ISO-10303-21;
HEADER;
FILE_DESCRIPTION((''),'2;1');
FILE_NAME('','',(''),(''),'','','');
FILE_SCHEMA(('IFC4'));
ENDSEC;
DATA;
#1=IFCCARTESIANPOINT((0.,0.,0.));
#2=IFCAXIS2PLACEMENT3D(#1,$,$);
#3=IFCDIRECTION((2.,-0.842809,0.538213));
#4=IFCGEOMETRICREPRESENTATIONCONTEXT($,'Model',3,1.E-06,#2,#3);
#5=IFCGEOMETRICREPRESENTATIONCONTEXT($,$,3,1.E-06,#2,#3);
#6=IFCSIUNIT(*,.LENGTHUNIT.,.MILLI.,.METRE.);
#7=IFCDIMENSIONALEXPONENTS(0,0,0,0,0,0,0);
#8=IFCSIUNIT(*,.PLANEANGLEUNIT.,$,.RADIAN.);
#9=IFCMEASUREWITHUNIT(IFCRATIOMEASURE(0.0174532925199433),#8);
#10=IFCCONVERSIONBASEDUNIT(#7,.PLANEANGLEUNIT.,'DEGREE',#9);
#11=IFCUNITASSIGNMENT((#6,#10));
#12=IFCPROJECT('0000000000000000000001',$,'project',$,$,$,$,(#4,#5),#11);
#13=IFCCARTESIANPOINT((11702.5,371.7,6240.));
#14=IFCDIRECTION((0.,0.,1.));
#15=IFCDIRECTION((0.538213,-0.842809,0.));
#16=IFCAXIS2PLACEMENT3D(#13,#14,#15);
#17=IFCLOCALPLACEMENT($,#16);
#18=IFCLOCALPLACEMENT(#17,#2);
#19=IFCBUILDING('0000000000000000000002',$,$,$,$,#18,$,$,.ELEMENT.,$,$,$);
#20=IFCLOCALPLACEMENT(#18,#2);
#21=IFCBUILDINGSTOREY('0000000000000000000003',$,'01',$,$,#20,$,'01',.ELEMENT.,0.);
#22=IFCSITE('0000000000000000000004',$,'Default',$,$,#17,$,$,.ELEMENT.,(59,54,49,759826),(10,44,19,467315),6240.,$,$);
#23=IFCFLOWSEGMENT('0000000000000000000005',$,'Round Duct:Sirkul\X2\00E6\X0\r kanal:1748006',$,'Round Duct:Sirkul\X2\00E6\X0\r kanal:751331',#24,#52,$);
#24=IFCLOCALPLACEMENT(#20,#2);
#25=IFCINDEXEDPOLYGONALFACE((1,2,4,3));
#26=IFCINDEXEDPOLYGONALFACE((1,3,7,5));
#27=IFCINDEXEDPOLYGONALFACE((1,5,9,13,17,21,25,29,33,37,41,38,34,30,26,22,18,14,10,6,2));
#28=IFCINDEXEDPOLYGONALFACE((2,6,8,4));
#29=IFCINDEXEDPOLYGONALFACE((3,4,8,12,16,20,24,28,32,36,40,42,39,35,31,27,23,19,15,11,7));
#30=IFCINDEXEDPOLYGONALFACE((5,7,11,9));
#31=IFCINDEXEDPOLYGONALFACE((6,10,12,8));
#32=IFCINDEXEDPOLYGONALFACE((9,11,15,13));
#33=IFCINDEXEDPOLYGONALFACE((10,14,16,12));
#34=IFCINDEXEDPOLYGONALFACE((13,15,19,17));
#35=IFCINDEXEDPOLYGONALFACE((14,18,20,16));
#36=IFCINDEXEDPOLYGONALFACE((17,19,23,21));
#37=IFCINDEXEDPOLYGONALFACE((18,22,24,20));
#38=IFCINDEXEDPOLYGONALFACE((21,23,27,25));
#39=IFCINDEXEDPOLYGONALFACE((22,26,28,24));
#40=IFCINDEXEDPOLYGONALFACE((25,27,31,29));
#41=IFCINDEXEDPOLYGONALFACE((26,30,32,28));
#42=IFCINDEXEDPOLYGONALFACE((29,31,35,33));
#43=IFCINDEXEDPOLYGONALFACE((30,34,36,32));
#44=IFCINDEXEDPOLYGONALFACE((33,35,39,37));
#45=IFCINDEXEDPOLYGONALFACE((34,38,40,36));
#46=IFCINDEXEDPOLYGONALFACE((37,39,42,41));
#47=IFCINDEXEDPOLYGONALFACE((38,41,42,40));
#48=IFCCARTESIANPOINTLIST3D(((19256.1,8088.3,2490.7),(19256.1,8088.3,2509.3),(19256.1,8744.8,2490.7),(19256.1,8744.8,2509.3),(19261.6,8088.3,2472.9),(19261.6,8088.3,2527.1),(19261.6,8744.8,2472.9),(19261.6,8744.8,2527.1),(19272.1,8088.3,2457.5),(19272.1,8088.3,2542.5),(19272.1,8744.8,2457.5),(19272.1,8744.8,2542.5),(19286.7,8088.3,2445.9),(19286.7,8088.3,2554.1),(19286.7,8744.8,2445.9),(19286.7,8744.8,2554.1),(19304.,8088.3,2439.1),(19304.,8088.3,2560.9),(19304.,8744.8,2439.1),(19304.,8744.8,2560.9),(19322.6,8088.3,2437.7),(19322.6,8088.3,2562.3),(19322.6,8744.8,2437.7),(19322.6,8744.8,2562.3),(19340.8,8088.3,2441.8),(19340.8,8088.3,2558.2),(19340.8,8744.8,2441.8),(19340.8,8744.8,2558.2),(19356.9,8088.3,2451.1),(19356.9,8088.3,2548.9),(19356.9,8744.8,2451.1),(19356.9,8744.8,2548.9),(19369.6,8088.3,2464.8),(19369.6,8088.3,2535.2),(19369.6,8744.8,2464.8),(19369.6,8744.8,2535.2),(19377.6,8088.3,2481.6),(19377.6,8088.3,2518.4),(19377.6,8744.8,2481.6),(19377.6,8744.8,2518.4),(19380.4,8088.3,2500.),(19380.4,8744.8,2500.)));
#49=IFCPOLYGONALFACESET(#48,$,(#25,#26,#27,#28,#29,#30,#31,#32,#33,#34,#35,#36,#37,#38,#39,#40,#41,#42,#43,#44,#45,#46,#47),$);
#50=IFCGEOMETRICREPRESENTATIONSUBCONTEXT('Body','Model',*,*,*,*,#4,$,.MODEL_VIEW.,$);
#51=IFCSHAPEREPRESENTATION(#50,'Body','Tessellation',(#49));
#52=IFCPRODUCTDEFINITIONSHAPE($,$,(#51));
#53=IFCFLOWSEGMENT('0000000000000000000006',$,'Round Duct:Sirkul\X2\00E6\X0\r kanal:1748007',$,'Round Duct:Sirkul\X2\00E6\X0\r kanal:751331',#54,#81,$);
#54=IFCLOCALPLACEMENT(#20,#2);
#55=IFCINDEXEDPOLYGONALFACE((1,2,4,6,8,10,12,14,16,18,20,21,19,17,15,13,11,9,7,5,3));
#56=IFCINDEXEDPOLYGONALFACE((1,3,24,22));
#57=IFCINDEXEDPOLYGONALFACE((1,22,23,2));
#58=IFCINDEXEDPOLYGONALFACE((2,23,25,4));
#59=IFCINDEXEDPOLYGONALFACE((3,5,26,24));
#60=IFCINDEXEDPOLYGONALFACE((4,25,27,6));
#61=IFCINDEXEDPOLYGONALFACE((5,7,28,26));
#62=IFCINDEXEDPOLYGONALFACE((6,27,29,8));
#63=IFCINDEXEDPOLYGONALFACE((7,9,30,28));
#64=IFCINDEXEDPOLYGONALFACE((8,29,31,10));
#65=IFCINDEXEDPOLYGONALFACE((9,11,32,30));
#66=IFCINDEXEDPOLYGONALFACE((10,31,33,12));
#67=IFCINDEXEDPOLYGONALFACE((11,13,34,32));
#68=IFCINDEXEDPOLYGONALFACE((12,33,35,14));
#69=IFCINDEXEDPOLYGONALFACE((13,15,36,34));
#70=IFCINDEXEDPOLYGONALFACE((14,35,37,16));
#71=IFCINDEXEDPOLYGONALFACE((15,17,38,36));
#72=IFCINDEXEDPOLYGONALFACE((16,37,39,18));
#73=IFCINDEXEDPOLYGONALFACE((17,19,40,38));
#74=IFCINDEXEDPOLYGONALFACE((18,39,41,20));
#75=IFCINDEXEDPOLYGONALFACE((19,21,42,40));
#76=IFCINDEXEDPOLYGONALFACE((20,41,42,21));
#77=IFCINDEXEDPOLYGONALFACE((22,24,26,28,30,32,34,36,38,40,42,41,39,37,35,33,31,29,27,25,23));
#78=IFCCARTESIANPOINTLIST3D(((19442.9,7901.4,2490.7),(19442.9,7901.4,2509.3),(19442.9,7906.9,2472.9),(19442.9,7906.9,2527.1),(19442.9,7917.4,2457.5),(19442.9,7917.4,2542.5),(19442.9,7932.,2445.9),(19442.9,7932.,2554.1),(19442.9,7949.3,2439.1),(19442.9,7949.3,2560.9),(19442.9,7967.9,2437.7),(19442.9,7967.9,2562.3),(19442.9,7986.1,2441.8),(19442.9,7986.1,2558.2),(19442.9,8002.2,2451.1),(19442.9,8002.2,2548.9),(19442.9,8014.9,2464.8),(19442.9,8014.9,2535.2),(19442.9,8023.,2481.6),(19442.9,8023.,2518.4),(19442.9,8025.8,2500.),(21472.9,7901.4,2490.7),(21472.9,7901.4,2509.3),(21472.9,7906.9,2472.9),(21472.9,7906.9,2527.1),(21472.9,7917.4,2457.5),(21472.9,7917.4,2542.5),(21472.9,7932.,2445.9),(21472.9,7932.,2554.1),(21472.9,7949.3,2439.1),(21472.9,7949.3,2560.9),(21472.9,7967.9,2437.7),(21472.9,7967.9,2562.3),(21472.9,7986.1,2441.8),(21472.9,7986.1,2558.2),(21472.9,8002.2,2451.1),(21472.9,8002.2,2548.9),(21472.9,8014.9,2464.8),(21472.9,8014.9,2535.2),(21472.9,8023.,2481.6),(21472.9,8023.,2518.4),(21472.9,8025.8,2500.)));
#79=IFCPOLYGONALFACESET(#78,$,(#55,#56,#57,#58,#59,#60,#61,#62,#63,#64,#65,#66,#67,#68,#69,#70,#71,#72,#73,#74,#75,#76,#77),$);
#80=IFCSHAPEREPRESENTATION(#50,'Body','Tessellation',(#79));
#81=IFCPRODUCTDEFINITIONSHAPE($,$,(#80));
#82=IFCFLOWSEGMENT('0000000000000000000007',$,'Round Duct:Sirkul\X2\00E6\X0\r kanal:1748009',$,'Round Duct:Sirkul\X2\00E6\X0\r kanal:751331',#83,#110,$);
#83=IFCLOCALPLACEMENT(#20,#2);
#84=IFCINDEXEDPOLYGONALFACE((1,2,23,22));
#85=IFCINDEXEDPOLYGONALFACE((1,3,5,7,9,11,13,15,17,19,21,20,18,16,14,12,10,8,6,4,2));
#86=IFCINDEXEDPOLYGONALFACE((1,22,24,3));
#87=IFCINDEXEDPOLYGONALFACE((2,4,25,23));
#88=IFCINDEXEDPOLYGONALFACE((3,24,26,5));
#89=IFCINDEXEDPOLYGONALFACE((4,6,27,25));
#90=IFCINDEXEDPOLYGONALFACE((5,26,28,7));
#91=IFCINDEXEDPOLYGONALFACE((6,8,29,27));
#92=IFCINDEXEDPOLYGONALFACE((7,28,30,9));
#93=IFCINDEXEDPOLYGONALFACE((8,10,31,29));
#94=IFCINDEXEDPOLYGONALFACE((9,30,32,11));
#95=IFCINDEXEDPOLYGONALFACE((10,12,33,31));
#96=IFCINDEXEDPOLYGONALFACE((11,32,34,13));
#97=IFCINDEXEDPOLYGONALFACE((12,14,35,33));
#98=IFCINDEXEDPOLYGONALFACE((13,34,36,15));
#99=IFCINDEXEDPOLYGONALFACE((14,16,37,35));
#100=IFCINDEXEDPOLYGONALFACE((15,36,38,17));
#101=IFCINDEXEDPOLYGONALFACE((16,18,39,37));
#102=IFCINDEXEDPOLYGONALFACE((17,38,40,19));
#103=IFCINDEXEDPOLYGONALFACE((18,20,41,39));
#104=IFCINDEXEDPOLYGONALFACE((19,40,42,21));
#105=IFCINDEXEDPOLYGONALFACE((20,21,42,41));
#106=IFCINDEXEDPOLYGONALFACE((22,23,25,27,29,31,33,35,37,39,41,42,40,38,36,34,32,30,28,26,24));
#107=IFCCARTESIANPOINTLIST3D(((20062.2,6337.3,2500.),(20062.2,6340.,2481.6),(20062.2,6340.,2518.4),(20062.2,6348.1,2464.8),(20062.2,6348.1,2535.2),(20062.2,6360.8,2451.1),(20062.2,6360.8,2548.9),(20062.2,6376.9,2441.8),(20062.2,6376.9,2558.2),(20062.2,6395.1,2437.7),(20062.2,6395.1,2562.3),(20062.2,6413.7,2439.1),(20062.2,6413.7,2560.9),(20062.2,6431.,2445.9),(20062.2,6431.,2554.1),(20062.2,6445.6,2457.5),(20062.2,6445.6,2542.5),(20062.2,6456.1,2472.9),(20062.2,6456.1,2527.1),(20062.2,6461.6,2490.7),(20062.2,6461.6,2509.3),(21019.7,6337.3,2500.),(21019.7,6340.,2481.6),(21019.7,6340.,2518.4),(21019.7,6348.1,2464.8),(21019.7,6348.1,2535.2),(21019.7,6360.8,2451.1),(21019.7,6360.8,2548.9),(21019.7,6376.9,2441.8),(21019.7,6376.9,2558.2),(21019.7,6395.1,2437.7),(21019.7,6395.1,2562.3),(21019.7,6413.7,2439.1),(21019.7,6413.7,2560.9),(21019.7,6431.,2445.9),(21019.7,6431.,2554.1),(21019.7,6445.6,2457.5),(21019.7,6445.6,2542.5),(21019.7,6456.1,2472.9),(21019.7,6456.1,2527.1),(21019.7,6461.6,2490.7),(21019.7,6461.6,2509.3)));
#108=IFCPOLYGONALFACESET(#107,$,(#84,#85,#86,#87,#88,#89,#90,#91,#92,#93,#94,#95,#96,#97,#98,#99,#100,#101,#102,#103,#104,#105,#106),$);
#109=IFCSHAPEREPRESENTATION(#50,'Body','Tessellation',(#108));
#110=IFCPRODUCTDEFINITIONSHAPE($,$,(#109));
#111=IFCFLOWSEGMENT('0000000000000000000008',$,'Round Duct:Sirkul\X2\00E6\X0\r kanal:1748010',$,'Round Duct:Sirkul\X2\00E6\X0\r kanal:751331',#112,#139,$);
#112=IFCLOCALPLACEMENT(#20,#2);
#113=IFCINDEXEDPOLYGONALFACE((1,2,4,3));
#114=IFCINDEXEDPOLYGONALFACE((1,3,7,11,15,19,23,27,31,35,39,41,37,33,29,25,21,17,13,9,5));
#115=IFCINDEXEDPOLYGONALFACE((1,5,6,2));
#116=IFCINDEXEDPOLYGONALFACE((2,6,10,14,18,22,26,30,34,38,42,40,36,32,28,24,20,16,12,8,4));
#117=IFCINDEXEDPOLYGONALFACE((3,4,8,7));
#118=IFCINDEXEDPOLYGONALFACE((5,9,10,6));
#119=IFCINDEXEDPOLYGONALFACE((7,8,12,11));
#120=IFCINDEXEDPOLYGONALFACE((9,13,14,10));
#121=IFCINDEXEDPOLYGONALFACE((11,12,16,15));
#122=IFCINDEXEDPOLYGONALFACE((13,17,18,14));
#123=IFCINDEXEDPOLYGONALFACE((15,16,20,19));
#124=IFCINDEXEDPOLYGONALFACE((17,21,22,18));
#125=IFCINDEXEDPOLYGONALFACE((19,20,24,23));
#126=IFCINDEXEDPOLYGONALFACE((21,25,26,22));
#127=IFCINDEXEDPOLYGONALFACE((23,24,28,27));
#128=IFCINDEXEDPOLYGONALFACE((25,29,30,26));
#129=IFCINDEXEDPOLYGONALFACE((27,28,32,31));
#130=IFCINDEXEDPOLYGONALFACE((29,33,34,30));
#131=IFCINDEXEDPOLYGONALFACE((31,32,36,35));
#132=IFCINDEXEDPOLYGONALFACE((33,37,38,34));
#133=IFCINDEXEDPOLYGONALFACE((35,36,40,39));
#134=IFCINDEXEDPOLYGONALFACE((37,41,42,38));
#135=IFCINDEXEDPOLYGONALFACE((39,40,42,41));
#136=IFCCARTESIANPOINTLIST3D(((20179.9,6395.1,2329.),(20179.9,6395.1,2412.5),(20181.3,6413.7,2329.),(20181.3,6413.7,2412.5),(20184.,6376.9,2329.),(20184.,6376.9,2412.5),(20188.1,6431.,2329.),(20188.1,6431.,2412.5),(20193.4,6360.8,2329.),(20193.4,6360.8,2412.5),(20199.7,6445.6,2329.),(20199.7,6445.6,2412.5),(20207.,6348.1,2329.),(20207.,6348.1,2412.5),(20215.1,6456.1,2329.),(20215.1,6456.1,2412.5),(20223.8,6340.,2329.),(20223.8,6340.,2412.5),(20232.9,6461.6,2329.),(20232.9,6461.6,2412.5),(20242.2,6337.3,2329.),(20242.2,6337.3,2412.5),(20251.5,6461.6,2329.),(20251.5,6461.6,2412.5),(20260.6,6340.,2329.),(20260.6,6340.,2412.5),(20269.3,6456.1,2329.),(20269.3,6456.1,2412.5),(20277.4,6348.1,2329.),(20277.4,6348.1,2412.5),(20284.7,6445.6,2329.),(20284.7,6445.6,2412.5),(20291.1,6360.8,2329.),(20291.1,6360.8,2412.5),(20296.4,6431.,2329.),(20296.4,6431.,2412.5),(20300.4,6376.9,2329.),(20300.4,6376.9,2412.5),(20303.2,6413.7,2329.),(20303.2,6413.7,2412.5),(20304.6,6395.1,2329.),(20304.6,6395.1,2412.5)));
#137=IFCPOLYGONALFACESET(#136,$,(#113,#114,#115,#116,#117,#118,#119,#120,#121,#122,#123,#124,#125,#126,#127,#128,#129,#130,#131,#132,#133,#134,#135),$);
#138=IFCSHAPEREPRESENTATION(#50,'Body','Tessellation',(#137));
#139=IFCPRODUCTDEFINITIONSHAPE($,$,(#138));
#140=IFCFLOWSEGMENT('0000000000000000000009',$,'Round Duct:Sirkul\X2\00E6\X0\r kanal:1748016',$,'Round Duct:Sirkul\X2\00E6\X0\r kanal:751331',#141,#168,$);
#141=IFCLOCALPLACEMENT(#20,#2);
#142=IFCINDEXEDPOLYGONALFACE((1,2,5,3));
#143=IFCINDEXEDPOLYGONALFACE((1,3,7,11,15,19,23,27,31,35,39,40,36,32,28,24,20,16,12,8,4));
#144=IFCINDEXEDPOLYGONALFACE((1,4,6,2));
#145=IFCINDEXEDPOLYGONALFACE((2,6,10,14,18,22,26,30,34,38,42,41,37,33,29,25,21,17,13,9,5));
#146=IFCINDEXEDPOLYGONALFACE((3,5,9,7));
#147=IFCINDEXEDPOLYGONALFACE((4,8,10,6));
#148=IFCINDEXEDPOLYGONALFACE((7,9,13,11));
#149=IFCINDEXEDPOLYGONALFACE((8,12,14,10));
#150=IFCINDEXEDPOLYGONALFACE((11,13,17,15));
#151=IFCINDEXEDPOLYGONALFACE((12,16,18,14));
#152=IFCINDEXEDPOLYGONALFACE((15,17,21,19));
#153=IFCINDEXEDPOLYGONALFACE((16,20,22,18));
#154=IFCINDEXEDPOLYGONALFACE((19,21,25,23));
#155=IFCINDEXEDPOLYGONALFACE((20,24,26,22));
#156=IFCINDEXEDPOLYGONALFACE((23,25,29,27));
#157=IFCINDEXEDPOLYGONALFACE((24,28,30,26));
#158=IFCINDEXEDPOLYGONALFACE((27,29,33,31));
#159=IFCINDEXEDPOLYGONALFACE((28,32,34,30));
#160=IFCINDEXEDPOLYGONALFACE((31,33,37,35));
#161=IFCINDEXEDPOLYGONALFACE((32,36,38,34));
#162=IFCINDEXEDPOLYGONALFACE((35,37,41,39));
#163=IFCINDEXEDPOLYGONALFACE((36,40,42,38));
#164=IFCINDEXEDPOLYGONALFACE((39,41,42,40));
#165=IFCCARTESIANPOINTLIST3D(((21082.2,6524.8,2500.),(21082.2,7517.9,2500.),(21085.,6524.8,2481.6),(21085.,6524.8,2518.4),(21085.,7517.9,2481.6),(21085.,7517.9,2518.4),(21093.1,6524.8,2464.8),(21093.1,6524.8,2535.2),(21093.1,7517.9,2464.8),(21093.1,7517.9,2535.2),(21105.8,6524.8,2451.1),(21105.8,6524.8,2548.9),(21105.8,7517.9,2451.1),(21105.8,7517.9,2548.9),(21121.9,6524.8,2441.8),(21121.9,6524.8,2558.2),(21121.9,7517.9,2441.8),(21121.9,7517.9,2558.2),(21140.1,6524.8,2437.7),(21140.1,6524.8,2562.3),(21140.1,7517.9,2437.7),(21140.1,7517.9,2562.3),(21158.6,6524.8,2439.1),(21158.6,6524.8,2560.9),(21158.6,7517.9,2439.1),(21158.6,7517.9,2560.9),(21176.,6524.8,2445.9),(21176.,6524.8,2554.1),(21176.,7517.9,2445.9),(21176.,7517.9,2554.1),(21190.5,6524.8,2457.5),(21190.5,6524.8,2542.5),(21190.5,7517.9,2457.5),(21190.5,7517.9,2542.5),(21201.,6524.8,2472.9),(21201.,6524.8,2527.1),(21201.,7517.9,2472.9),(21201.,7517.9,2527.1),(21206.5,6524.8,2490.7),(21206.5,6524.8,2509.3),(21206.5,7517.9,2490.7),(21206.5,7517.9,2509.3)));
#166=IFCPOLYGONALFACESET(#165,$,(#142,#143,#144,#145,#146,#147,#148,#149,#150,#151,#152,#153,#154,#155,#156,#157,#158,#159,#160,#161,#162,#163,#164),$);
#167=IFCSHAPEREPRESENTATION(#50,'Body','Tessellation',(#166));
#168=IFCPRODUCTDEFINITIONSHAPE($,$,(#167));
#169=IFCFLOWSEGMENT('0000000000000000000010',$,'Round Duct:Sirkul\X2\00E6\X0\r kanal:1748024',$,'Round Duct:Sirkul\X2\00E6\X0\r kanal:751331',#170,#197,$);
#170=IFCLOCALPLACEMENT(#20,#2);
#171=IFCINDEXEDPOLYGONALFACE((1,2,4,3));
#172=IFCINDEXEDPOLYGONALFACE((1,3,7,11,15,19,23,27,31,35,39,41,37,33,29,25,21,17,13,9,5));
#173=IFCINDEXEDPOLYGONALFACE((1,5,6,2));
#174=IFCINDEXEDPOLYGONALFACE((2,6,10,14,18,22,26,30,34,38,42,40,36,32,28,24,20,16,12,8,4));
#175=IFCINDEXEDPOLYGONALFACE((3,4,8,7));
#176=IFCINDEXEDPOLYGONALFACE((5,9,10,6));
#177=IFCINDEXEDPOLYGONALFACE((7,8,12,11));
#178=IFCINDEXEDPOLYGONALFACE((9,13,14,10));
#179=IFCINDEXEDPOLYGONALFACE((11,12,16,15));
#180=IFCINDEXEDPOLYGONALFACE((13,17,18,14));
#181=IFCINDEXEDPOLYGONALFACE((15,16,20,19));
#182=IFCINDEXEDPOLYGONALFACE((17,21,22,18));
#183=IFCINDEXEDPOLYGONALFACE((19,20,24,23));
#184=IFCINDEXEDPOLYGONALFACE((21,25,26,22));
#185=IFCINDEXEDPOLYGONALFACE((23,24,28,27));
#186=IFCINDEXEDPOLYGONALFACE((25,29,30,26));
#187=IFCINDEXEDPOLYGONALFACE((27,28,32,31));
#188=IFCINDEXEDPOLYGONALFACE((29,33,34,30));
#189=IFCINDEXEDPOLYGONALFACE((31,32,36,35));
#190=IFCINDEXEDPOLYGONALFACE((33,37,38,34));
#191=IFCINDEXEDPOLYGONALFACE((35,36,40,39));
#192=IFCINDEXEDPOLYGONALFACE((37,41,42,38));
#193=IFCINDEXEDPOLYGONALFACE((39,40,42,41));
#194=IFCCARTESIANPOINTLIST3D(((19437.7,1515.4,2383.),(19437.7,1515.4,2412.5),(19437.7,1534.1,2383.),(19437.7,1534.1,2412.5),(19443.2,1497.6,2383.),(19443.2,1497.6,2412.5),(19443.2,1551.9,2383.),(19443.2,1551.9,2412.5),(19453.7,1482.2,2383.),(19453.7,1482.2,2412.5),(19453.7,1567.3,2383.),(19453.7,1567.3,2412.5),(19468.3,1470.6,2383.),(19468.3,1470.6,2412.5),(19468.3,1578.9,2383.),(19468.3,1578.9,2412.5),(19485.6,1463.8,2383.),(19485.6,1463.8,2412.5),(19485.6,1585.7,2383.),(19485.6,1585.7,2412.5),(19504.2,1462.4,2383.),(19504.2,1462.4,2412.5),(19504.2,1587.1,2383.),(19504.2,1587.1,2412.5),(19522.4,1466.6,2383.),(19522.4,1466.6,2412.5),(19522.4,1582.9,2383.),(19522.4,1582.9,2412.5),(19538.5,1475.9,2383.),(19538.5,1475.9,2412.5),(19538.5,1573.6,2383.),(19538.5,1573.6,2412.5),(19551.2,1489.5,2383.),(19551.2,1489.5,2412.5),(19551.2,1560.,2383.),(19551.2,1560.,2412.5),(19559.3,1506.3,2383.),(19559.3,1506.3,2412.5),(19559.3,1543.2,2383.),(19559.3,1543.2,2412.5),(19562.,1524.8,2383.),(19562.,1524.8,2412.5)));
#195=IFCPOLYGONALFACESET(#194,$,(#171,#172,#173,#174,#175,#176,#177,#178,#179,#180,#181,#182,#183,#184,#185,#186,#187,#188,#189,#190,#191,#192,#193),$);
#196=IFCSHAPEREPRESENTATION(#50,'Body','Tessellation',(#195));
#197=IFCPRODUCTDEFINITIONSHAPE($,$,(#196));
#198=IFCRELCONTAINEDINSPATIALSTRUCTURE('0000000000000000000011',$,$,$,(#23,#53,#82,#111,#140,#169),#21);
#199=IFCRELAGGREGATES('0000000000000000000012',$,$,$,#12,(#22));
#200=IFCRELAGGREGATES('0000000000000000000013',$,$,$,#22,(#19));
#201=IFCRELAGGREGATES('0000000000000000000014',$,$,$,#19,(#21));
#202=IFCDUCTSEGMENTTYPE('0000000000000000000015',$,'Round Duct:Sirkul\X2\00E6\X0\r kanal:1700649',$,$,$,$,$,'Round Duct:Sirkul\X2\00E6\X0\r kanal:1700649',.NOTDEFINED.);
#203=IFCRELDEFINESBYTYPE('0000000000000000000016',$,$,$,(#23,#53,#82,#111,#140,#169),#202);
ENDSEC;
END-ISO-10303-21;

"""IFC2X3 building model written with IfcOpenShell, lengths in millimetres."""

from ifc_helpers import new_model, entity, si_unit, converted_unit, direction, frame, frame_2d, origin, origin_2d_with_axis, place, context, subcontext, project, spatial, circle, extrude, type_object, element, save


model = new_model("IFC2X3")

# Units and contexts
model_context = context("Model", 3, precision=1e-06, world=origin(), true_north=direction((2.0, -0.842809, 0.538213)))
context_of_model = context(None, 3, precision=1e-06, world=origin(), true_north=direction((2.0, -0.842809, 0.538213)))
body_context = subcontext(model_context, "Body", "Model", "MODEL_VIEW")
ifc_project = project(units=[si_unit("LENGTHUNIT", "METRE", prefix="MILLI"), converted_unit("PLANEANGLEUNIT", "DEGREE", entity("IfcRatioMeasure", 0.0174532925199433), si_unit("PLANEANGLEUNIT", "RADIAN"), dimensions=[0, 0, 0, 0, 0, 0, 0])], contexts=[model_context, context_of_model])

# Site, building, storey
site_placement = place(None, frame((11702.5, 371.7, 6240.0), z_axis=(0.0, 0.0, 1.0), x_axis=(0.538213, -0.842809, 0.0)))
site = spatial("IfcSite", under=ifc_project, at=site_placement, Name="Default", CompositionType="ELEMENT", RefLatitude=(59, 54, 49, 759826), RefLongitude=(10, 44, 19, 467315), RefElevation=6240.0)
building_placement = place(site_placement, origin())
building = spatial("IfcBuilding", under=site, at=building_placement, CompositionType="ELEMENT")
storey_placement = place(building_placement, origin())
storey = spatial("IfcBuildingStorey", under=building, at=storey_placement, Name="01", LongName="01", CompositionType="ELEMENT", Elevation=0.0)

# Flow segments
duct_segment_type_1 = type_object("IfcDuctSegmentType", Name="Round Duct:Sirkulær kanal:1700649", ElementType="Round Duct:Sirkulær kanal:1700649", PredefinedType="NOTDEFINED")
flow_segment_1_placement = place(storey_placement, origin())
element("IfcFlowSegment", 1, at=flow_segment_1_placement, inside=storey, type_object=duct_segment_type_1, Name="Round Duct:Sirkulær kanal:1748006", ObjectType="Round Duct:Sirkulær kanal:751331", context=body_context, shape_type="SweptSolid", body=[
    extrude(circle(Radius=62.5, at=origin_2d_with_axis()), frame((19317.9, 8088.3, 2500.0), z_axis=(0.0, 1.0, 0.0), x_axis=(1.0, 0.0, 0.0)), (0.0, 0.0, 1.0), 656.5),
])
flow_segment_2_placement = place(storey_placement, origin())
element("IfcFlowSegment", 2, at=flow_segment_2_placement, inside=storey, type_object=duct_segment_type_1, Name="Round Duct:Sirkulær kanal:1748007", ObjectType="Round Duct:Sirkulær kanal:751331", context=body_context, shape_type="SweptSolid", body=[
    extrude(circle(Radius=62.5, at=frame_2d((0.0, 0.0), x_axis=(1.0, 0.0))), frame((19442.9, 7963.3, 2500.0), z_axis=(1.0, 0.0, 0.0), x_axis=(0.0, 1.0, 0.0)), (0.0, 0.0, 1.0), 2030.0),
])
flow_segment_3_placement = place(storey_placement, origin())
element("IfcFlowSegment", 3, at=flow_segment_3_placement, inside=storey, type_object=duct_segment_type_1, Name="Round Duct:Sirkulær kanal:1748009", ObjectType="Round Duct:Sirkulær kanal:751331", context=body_context, shape_type="SweptSolid", body=[
    extrude(circle(Radius=62.5, at=origin_2d_with_axis()), frame((20062.2, 6399.8, 2500.0), z_axis=(1.0, 0.0, 0.0), x_axis=(0.0, -1.0, 0.0)), (0.0, 0.0, 1.0), 957.5),
])
flow_segment_4_placement = place(storey_placement, origin())
element("IfcFlowSegment", 4, at=flow_segment_4_placement, inside=storey, type_object=duct_segment_type_1, Name="Round Duct:Sirkulær kanal:1748010", ObjectType="Round Duct:Sirkulær kanal:751331", context=body_context, shape_type="SweptSolid", body=[
    extrude(circle(Radius=62.5, at=frame_2d((0.0, 0.0), x_axis=(1.0, 0.0))), frame((20242.2, 6399.8, 2329.0), z_axis=(0.0, 0.0, 1.0), x_axis=(0.0, -1.0, 0.0)), (0.0, 0.0, 1.0), 83.5),
])
flow_segment_5_placement = place(storey_placement, origin())
element("IfcFlowSegment", 5, at=flow_segment_5_placement, inside=storey, type_object=duct_segment_type_1, Name="Round Duct:Sirkulær kanal:1748016", ObjectType="Round Duct:Sirkulær kanal:751331", context=body_context, shape_type="SweptSolid", body=[
    extrude(circle(Radius=62.5, at=origin_2d_with_axis()), frame((21144.7, 6524.8, 2500.0), z_axis=(0.0, 1.0, 0.0), x_axis=(-1.0, 0.0, 0.0)), (0.0, 0.0, 1.0), 993.1),
])
flow_segment_6_placement = place(storey_placement, origin())
element("IfcFlowSegment", 6, at=flow_segment_6_placement, inside=storey, type_object=duct_segment_type_1, Name="Round Duct:Sirkulær kanal:1748024", ObjectType="Round Duct:Sirkulær kanal:751331", context=body_context, shape_type="SweptSolid", body=[
    extrude(circle(Radius=62.5, at=frame_2d((0.0, 0.0), x_axis=(1.0, 0.0))), frame((19499.5, 1524.8, 2383.0)), (0.0, 0.0, 1.0), 29.5),
])

save(model, "model.ifc")
